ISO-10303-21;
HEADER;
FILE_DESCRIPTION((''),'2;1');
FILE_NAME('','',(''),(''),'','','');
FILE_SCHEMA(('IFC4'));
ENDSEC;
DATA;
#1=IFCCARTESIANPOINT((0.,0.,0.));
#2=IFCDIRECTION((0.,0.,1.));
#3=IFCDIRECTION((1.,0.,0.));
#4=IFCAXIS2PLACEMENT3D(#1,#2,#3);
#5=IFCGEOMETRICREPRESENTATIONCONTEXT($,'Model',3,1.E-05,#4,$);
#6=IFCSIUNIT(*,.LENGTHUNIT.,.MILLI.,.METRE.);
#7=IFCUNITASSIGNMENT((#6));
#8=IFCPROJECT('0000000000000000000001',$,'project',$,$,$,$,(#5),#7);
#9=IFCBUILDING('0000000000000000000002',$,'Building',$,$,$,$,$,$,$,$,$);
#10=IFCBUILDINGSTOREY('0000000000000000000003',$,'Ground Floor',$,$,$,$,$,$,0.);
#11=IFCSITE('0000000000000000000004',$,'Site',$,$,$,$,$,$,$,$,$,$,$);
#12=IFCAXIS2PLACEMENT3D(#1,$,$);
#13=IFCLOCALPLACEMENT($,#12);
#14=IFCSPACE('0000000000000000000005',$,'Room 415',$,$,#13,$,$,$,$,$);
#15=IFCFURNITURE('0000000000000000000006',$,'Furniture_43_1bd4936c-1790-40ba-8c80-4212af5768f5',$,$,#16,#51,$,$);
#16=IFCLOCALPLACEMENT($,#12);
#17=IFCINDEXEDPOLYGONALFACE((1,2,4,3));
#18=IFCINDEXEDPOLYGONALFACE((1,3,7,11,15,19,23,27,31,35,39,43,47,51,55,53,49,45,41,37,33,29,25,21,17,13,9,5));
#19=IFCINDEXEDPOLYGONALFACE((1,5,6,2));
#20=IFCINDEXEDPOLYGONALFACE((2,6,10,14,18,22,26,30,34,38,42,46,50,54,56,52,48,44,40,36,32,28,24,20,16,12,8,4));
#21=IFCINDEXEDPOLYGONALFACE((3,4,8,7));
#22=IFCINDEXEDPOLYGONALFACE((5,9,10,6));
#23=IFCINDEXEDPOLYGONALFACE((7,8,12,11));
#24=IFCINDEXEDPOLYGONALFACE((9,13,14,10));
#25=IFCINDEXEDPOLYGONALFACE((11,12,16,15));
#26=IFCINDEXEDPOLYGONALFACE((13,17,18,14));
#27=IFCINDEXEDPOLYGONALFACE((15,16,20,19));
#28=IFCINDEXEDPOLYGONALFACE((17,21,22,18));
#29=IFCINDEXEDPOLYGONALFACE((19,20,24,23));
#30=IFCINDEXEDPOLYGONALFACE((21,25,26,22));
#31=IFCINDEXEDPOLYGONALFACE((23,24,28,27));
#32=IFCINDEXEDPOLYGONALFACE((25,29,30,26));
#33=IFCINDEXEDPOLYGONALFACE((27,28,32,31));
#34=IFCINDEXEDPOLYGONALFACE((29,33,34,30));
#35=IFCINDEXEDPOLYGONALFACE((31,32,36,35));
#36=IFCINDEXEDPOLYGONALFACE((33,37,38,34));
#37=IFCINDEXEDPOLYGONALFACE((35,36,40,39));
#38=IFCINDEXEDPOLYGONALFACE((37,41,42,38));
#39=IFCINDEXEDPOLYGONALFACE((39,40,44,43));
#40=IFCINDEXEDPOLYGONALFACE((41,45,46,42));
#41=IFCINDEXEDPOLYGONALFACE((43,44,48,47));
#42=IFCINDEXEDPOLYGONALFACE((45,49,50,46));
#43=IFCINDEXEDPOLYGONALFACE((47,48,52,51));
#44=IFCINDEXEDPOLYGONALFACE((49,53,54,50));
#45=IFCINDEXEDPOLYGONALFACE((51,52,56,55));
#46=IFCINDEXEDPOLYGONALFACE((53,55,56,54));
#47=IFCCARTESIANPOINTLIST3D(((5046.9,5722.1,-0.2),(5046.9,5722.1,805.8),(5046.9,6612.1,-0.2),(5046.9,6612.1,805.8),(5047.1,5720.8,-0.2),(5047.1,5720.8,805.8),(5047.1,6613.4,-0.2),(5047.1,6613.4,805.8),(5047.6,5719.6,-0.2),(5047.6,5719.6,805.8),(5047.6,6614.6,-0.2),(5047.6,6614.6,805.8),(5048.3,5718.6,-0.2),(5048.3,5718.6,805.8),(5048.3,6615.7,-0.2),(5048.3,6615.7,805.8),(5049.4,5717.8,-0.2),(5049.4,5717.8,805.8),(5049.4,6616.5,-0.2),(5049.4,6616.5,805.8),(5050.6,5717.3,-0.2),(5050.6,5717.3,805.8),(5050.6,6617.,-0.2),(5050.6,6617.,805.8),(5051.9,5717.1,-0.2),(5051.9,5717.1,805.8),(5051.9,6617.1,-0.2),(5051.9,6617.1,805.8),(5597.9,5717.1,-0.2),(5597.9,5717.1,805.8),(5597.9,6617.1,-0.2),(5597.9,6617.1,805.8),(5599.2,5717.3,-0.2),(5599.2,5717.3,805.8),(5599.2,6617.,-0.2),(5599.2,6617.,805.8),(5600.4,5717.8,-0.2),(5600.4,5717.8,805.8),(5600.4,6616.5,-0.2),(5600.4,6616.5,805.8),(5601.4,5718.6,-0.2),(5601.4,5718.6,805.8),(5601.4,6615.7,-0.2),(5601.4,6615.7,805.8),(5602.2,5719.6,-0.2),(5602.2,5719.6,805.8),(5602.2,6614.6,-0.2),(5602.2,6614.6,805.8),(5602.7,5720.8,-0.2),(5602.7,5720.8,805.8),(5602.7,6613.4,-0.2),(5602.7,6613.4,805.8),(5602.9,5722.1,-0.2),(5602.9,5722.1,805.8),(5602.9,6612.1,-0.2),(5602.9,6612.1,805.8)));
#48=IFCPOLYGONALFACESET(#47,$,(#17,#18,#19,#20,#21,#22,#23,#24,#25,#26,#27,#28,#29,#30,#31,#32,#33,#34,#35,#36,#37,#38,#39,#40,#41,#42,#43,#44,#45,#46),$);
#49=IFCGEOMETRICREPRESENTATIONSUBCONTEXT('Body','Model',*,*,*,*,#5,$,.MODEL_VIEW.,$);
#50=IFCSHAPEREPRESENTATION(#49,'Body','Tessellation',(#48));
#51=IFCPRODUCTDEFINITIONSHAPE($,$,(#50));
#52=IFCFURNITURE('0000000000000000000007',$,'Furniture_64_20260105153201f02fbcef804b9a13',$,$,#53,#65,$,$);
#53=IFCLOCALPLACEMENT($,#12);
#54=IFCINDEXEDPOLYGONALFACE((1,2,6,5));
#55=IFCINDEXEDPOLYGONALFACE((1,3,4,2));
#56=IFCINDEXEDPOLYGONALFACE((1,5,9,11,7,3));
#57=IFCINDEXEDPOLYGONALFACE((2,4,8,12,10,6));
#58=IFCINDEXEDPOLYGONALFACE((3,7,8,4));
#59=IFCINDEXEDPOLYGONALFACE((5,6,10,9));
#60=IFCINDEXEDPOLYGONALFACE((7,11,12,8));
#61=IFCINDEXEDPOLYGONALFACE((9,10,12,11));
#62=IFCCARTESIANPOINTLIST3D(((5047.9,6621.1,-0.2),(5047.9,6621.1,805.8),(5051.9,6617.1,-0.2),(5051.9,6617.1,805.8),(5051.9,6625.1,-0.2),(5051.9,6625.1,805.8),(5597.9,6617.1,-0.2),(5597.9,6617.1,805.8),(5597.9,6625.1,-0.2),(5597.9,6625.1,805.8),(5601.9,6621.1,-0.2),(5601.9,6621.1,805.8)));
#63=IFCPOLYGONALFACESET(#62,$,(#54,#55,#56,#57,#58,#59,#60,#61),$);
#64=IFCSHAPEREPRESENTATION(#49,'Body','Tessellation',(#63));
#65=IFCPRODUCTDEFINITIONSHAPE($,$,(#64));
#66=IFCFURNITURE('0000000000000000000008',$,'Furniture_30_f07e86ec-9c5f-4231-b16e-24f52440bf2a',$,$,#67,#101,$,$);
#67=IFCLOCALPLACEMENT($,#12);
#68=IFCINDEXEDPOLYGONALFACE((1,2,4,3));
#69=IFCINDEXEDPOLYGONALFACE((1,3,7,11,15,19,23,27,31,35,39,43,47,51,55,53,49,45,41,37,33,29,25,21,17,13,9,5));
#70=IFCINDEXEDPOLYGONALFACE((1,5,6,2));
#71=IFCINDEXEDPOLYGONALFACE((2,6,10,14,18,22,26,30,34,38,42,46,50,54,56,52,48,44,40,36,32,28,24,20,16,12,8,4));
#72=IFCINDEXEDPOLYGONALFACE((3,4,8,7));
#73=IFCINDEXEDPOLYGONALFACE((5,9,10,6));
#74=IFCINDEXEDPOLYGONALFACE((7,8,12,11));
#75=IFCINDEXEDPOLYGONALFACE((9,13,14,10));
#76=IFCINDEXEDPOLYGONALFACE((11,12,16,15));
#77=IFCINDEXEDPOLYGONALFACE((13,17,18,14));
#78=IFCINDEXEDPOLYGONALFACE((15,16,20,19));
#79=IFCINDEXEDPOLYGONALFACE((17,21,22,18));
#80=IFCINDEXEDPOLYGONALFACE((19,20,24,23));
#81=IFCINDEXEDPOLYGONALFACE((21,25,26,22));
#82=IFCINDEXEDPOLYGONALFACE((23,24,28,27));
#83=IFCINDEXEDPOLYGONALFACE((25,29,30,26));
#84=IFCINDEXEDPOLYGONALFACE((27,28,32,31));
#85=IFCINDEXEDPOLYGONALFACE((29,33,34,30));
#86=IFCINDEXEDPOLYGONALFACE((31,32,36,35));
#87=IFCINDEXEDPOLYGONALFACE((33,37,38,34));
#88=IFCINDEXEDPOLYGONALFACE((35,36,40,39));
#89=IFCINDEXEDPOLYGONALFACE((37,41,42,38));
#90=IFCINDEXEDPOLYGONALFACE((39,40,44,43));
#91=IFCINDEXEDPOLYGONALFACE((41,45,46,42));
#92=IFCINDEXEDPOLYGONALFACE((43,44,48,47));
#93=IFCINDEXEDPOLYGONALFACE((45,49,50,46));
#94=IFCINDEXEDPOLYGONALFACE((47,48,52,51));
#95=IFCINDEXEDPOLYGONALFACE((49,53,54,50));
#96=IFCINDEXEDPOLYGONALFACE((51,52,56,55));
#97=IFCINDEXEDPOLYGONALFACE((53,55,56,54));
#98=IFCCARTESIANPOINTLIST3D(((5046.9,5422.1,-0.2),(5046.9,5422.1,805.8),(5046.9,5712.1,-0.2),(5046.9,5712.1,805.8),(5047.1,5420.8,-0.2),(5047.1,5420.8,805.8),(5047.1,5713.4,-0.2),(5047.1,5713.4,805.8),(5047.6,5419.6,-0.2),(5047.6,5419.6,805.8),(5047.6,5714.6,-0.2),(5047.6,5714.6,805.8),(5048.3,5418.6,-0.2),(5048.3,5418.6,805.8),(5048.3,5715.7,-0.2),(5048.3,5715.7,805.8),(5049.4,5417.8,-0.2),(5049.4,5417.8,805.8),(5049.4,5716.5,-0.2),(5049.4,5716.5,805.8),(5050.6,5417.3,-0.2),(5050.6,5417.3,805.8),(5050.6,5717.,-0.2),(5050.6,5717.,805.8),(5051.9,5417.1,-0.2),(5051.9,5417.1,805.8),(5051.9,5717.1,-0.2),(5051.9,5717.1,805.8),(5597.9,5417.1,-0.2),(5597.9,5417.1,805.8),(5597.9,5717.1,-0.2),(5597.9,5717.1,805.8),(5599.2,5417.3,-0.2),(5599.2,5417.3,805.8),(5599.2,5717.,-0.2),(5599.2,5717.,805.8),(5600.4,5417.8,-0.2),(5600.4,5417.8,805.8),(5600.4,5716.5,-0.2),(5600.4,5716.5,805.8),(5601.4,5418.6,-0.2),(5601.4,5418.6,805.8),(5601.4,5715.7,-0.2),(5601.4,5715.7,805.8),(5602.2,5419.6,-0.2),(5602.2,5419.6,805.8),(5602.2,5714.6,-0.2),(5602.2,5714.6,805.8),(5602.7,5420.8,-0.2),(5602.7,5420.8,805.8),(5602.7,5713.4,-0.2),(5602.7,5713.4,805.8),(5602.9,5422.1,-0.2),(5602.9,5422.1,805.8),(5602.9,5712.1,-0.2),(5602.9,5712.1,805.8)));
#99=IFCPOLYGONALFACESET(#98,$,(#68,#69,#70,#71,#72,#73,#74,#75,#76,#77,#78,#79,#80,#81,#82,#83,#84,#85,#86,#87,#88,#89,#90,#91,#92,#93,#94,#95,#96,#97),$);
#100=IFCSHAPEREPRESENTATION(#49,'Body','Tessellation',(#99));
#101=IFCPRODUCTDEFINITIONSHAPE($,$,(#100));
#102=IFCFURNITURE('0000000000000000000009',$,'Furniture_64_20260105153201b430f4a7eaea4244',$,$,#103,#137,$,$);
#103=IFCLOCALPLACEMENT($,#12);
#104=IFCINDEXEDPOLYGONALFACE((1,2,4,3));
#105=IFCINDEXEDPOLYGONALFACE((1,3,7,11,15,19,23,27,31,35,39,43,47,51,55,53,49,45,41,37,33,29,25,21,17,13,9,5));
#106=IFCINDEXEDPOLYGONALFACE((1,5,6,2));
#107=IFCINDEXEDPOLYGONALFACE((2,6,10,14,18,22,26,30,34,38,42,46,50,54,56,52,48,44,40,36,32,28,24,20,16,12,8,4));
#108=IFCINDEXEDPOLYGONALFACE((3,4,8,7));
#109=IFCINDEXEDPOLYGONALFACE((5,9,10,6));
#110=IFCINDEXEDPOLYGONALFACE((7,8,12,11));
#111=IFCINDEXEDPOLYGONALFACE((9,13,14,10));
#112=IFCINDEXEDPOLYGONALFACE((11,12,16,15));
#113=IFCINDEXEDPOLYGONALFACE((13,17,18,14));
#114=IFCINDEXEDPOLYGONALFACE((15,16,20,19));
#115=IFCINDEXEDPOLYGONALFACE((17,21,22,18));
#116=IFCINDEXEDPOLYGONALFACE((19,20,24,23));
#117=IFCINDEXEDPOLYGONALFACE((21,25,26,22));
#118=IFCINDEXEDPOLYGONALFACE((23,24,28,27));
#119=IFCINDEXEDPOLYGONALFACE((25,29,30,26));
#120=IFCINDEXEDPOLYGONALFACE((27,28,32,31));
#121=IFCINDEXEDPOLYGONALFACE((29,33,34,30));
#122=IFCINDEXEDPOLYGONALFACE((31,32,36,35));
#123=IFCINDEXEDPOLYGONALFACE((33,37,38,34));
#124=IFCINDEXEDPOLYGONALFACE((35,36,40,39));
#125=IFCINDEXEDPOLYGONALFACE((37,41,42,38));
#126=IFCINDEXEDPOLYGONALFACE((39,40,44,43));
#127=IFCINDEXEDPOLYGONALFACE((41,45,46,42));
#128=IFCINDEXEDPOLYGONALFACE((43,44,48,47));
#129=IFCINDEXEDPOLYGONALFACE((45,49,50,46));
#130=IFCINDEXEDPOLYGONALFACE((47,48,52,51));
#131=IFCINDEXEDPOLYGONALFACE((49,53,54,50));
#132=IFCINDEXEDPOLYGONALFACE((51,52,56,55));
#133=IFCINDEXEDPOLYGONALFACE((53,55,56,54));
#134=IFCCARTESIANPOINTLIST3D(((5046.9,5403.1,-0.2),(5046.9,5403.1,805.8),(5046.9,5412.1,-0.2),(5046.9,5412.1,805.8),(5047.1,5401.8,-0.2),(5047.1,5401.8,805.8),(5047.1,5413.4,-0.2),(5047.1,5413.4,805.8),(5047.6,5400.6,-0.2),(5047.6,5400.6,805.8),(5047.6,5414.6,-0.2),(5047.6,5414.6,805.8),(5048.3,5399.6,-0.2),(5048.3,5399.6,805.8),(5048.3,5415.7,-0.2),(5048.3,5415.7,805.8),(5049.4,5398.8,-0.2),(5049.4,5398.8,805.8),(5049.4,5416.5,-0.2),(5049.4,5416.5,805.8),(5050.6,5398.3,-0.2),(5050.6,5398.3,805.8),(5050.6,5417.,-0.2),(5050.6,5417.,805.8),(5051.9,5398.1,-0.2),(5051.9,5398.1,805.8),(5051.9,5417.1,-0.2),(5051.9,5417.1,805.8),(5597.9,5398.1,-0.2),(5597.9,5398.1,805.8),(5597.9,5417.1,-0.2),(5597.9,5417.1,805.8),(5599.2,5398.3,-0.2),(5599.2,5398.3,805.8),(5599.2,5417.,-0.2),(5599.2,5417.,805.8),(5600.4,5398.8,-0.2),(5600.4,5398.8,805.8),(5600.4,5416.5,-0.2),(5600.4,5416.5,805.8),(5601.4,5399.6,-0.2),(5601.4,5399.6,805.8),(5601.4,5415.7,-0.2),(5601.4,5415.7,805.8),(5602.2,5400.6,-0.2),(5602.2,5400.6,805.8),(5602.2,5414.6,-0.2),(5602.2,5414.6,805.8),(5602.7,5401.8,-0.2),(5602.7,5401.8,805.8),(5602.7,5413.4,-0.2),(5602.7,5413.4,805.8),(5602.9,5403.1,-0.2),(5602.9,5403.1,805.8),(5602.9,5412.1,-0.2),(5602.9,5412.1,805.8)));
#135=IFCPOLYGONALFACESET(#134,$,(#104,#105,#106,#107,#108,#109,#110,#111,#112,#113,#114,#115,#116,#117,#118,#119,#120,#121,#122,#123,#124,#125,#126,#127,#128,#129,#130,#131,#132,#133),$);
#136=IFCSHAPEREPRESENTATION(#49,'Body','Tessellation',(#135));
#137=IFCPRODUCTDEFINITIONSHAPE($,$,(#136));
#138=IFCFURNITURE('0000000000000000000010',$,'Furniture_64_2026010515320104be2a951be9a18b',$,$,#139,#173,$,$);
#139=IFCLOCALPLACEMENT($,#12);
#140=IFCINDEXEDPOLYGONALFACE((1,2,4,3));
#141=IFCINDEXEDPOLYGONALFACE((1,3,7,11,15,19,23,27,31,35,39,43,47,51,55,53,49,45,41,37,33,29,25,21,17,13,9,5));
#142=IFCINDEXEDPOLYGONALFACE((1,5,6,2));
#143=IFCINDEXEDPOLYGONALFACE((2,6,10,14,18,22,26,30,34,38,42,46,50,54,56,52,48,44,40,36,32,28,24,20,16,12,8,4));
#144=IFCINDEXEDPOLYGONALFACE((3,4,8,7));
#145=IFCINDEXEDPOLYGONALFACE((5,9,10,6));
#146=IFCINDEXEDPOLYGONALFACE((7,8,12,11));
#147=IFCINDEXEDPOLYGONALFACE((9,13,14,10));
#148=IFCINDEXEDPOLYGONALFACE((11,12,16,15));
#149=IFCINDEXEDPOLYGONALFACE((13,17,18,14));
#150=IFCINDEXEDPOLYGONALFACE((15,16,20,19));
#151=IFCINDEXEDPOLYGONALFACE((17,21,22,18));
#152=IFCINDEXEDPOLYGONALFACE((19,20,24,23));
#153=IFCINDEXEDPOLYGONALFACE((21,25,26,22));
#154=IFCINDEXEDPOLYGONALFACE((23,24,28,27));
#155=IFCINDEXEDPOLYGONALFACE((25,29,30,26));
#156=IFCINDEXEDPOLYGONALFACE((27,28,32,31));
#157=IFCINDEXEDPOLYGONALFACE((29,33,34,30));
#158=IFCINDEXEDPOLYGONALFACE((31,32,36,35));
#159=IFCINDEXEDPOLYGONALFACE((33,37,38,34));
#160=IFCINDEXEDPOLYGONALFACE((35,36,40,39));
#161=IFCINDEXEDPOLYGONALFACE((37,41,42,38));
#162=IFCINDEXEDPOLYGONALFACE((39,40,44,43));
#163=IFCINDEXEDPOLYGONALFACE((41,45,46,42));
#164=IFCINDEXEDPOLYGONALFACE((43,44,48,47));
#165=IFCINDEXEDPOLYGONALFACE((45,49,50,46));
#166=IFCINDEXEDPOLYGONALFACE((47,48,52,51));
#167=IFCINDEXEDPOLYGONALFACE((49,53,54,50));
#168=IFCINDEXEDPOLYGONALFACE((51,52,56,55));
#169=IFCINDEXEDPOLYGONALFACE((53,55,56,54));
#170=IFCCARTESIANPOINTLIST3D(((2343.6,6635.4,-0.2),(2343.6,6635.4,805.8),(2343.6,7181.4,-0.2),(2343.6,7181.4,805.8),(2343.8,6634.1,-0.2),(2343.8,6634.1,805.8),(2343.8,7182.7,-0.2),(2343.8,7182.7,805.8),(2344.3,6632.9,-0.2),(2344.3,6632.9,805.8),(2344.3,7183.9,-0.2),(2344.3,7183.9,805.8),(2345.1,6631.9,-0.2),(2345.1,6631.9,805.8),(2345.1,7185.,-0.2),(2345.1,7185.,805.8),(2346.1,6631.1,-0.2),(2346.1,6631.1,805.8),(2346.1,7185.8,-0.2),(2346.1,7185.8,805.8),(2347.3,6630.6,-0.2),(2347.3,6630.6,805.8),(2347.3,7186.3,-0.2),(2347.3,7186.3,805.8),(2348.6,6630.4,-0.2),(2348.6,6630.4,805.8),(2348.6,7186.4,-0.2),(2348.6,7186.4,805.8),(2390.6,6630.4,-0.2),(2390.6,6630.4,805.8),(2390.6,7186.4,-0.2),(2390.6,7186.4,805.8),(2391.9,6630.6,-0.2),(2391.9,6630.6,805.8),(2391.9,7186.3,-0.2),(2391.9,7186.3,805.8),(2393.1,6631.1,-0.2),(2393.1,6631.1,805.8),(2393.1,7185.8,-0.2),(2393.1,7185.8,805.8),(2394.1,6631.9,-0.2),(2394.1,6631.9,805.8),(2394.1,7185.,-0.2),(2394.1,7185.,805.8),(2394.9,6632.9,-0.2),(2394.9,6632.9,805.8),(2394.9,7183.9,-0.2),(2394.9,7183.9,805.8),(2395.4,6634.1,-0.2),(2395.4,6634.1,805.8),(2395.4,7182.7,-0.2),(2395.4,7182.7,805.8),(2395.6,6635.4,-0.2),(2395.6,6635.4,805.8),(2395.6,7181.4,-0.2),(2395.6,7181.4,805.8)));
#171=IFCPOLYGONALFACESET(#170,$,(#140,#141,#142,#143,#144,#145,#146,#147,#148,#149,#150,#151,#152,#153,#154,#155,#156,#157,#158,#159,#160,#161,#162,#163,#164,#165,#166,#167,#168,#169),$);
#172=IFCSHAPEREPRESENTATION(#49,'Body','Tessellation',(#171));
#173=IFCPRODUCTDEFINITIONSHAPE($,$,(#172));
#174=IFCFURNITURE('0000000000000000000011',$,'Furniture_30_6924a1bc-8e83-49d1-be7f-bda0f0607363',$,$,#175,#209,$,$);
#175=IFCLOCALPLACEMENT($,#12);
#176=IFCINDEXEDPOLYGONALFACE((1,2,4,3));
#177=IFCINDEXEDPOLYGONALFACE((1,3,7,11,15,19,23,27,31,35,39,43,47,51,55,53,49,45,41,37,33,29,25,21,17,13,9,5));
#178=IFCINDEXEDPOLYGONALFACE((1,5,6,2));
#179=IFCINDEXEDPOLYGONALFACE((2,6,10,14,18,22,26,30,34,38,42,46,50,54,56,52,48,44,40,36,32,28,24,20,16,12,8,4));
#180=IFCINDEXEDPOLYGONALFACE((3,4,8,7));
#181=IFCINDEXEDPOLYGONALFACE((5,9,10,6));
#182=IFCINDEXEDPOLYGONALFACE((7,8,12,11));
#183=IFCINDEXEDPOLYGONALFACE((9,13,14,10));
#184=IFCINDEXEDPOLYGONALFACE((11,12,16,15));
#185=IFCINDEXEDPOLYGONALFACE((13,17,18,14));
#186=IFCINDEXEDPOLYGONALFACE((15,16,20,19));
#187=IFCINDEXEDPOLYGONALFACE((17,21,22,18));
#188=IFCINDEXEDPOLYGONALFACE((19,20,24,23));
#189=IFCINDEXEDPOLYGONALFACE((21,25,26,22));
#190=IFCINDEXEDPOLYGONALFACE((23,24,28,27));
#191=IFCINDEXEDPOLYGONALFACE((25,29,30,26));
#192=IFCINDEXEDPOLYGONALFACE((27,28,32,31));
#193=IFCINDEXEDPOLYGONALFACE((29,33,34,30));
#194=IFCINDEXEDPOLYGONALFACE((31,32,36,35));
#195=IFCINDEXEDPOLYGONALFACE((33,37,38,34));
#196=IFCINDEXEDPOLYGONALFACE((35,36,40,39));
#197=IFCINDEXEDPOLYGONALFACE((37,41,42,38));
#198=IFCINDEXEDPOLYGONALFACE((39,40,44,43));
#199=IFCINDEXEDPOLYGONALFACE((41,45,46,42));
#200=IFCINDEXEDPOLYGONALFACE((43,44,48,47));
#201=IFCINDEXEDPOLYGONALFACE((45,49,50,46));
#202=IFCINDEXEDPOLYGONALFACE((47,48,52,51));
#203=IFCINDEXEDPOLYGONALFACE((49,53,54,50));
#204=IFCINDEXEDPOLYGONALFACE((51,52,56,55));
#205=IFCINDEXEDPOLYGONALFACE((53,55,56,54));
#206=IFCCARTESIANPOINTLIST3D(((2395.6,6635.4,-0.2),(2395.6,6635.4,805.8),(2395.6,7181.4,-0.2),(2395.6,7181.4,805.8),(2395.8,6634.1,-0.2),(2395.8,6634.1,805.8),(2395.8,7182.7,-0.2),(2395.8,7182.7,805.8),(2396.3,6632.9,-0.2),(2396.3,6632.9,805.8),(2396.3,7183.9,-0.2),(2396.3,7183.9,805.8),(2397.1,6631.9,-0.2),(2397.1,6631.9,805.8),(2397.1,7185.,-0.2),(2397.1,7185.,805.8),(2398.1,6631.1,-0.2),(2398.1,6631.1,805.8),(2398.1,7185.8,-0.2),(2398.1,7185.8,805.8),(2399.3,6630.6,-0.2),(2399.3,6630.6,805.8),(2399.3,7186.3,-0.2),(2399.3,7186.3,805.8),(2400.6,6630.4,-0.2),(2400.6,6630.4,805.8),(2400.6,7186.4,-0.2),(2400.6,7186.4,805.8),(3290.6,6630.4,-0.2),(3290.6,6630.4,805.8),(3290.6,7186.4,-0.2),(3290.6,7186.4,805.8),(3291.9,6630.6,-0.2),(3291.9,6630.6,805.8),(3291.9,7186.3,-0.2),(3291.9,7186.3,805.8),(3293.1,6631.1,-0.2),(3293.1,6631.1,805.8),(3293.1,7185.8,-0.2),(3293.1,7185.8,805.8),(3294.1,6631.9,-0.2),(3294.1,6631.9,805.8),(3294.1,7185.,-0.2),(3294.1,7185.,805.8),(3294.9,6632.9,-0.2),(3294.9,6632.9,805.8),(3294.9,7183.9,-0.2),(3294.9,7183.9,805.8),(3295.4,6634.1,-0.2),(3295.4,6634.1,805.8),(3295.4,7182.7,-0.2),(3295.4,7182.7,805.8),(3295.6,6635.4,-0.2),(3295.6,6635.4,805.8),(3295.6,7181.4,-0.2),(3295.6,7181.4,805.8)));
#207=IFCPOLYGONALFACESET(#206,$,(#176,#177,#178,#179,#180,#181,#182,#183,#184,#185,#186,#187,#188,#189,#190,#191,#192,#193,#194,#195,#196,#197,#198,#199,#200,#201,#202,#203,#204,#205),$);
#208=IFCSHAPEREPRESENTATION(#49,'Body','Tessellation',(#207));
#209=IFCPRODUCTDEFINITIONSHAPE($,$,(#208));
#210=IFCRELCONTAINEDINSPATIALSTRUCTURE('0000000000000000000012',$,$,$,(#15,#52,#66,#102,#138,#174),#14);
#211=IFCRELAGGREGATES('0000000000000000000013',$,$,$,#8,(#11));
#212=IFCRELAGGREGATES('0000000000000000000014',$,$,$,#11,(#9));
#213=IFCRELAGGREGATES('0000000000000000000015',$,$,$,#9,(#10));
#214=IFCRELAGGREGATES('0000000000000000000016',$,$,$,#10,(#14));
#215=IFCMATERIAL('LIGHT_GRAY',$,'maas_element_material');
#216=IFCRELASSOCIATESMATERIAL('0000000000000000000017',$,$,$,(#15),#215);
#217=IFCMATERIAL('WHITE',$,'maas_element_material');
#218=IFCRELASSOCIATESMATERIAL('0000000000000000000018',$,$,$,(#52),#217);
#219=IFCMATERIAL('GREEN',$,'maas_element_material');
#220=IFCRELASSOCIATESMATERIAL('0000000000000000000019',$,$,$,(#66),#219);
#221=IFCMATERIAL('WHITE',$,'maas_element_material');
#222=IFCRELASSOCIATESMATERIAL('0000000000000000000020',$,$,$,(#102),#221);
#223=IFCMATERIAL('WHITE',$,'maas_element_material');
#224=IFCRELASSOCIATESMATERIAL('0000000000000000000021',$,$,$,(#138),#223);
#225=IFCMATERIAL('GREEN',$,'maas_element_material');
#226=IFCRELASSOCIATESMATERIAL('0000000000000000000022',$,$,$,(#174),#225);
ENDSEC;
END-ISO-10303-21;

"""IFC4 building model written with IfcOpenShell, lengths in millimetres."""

from ifc_helpers import new_model, si_unit, frame, origin, origin_with_axes, place, context, subcontext, project, spatial, rounded_rectangle, extrude, material, element, save


model = new_model("IFC4")

# Units and contexts
model_context = context("Model", 3, precision=1e-05, world=origin_with_axes())
body_context = subcontext(model_context, "Body", "Model", "MODEL_VIEW")
ifc_project = project(units=[si_unit("LENGTHUNIT", "METRE", prefix="MILLI")], contexts=[model_context])

# Site, building, storey, space
site = spatial("IfcSite", under=ifc_project, Name="Site")
building = spatial("IfcBuilding", under=site, Name="Building")
storey = spatial("IfcBuildingStorey", under=building, Name="Ground Floor", Elevation=0.0)
space_placement = place(None, origin())
space = spatial("IfcSpace", under=storey, at=space_placement, Name="Room 415")

# Furniture
ifc_material_1 = material(Name="LIGHT_GRAY", Category="maas_element_material")
furniture_1_placement = place(space_placement, frame((5324.9, 6167.1, 402.8), z_axis=(0.0, 0.0, 1.0), x_axis=(0.0, -1.0, 0.0)))
element("IfcFurniture", 1, at=furniture_1_placement, inside=space, material=ifc_material_1, Name="Furniture_43_1bd4936c-1790-40ba-8c80-4212af5768f5", context=body_context, shape_type="SweptSolid", body=[
    extrude(rounded_rectangle(XDim=900.0, YDim=556.0, RoundingRadius=5.0), frame((0.0, 0.0, -403.0), z_axis=(0.0, 0.0, 1.0), x_axis=(1.0, 0.0, 0.0)), (0.0, 0.0, 1.0), 806.0),
])
ifc_material_2 = material(Name="WHITE", Category="maas_element_material")
furniture_2_placement = place(space_placement, frame((5324.9, 6621.1, 402.8), z_axis=(0.0, 0.0, 1.0), x_axis=(0.0, -1.0, 0.0)))
element("IfcFurniture", 2, at=furniture_2_placement, inside=space, material=ifc_material_2, Name="Furniture_64_20260105153201f02fbcef804b9a13", context=body_context, shape_type="SweptSolid", body=[
    extrude(rounded_rectangle(XDim=8.0, YDim=556.0, RoundingRadius=5.0), frame((0.0, 0.0, -403.0), z_axis=(0.0, 0.0, 1.0), x_axis=(1.0, 0.0, 0.0)), (0.0, 0.0, 1.0), 806.0),
])
ifc_material_3 = material(Name="GREEN", Category="maas_element_material")
furniture_3_placement = place(space_placement, frame((5324.9, 5567.1, 402.8), z_axis=(0.0, 0.0, 1.0), x_axis=(0.0, -1.0, 0.0)))
element("IfcFurniture", 3, at=furniture_3_placement, inside=space, material=ifc_material_3, Name="Furniture_30_f07e86ec-9c5f-4231-b16e-24f52440bf2a", context=body_context, shape_type="SweptSolid", body=[
    extrude(rounded_rectangle(XDim=300.0, YDim=556.0, RoundingRadius=5.0), frame((0.0, 0.0, -403.0), z_axis=(0.0, 0.0, 1.0), x_axis=(1.0, 0.0, 0.0)), (0.0, 0.0, 1.0), 806.0),
])
ifc_material_4 = material(Name="WHITE", Category="maas_element_material")
furniture_4_placement = place(space_placement, frame((5324.9, 5407.6, 402.8), z_axis=(0.0, 0.0, 1.0), x_axis=(0.0, -1.0, 0.0)))
element("IfcFurniture", 4, at=furniture_4_placement, inside=space, material=ifc_material_4, Name="Furniture_64_20260105153201b430f4a7eaea4244", context=body_context, shape_type="SweptSolid", body=[
    extrude(rounded_rectangle(XDim=19.0, YDim=556.0, RoundingRadius=5.0), frame((0.0, 0.0, -403.0), z_axis=(0.0, 0.0, 1.0), x_axis=(1.0, 0.0, 0.0)), (0.0, 0.0, 1.0), 806.0),
])
ifc_material_5 = material(Name="WHITE", Category="maas_element_material")
furniture_5_placement = place(space_placement, frame((2369.6, 6908.4, 402.8), z_axis=(0.0, 0.0, 1.0), x_axis=(1.0, 0.0, 0.0)))
element("IfcFurniture", 5, at=furniture_5_placement, inside=space, material=ifc_material_5, Name="Furniture_64_2026010515320104be2a951be9a18b", context=body_context, shape_type="SweptSolid", body=[
    extrude(rounded_rectangle(XDim=52.0, YDim=556.0, RoundingRadius=5.0), frame((0.0, 0.0, -403.0), z_axis=(0.0, 0.0, 1.0), x_axis=(1.0, 0.0, 0.0)), (0.0, 0.0, 1.0), 806.0),
])
ifc_material_6 = material(Name="GREEN", Category="maas_element_material")
furniture_6_placement = place(space_placement, frame((2845.6, 6908.4, 402.8), z_axis=(0.0, 0.0, 1.0), x_axis=(1.0, 0.0, 0.0)))
element("IfcFurniture", 6, at=furniture_6_placement, inside=space, material=ifc_material_6, Name="Furniture_30_6924a1bc-8e83-49d1-be7f-bda0f0607363", context=body_context, shape_type="SweptSolid", body=[
    extrude(rounded_rectangle(XDim=900.0, YDim=556.0, RoundingRadius=5.0), frame((0.0, 0.0, -403.0), z_axis=(0.0, 0.0, 1.0), x_axis=(1.0, 0.0, 0.0)), (0.0, 0.0, 1.0), 806.0),
])

save(model, "model.ifc")
